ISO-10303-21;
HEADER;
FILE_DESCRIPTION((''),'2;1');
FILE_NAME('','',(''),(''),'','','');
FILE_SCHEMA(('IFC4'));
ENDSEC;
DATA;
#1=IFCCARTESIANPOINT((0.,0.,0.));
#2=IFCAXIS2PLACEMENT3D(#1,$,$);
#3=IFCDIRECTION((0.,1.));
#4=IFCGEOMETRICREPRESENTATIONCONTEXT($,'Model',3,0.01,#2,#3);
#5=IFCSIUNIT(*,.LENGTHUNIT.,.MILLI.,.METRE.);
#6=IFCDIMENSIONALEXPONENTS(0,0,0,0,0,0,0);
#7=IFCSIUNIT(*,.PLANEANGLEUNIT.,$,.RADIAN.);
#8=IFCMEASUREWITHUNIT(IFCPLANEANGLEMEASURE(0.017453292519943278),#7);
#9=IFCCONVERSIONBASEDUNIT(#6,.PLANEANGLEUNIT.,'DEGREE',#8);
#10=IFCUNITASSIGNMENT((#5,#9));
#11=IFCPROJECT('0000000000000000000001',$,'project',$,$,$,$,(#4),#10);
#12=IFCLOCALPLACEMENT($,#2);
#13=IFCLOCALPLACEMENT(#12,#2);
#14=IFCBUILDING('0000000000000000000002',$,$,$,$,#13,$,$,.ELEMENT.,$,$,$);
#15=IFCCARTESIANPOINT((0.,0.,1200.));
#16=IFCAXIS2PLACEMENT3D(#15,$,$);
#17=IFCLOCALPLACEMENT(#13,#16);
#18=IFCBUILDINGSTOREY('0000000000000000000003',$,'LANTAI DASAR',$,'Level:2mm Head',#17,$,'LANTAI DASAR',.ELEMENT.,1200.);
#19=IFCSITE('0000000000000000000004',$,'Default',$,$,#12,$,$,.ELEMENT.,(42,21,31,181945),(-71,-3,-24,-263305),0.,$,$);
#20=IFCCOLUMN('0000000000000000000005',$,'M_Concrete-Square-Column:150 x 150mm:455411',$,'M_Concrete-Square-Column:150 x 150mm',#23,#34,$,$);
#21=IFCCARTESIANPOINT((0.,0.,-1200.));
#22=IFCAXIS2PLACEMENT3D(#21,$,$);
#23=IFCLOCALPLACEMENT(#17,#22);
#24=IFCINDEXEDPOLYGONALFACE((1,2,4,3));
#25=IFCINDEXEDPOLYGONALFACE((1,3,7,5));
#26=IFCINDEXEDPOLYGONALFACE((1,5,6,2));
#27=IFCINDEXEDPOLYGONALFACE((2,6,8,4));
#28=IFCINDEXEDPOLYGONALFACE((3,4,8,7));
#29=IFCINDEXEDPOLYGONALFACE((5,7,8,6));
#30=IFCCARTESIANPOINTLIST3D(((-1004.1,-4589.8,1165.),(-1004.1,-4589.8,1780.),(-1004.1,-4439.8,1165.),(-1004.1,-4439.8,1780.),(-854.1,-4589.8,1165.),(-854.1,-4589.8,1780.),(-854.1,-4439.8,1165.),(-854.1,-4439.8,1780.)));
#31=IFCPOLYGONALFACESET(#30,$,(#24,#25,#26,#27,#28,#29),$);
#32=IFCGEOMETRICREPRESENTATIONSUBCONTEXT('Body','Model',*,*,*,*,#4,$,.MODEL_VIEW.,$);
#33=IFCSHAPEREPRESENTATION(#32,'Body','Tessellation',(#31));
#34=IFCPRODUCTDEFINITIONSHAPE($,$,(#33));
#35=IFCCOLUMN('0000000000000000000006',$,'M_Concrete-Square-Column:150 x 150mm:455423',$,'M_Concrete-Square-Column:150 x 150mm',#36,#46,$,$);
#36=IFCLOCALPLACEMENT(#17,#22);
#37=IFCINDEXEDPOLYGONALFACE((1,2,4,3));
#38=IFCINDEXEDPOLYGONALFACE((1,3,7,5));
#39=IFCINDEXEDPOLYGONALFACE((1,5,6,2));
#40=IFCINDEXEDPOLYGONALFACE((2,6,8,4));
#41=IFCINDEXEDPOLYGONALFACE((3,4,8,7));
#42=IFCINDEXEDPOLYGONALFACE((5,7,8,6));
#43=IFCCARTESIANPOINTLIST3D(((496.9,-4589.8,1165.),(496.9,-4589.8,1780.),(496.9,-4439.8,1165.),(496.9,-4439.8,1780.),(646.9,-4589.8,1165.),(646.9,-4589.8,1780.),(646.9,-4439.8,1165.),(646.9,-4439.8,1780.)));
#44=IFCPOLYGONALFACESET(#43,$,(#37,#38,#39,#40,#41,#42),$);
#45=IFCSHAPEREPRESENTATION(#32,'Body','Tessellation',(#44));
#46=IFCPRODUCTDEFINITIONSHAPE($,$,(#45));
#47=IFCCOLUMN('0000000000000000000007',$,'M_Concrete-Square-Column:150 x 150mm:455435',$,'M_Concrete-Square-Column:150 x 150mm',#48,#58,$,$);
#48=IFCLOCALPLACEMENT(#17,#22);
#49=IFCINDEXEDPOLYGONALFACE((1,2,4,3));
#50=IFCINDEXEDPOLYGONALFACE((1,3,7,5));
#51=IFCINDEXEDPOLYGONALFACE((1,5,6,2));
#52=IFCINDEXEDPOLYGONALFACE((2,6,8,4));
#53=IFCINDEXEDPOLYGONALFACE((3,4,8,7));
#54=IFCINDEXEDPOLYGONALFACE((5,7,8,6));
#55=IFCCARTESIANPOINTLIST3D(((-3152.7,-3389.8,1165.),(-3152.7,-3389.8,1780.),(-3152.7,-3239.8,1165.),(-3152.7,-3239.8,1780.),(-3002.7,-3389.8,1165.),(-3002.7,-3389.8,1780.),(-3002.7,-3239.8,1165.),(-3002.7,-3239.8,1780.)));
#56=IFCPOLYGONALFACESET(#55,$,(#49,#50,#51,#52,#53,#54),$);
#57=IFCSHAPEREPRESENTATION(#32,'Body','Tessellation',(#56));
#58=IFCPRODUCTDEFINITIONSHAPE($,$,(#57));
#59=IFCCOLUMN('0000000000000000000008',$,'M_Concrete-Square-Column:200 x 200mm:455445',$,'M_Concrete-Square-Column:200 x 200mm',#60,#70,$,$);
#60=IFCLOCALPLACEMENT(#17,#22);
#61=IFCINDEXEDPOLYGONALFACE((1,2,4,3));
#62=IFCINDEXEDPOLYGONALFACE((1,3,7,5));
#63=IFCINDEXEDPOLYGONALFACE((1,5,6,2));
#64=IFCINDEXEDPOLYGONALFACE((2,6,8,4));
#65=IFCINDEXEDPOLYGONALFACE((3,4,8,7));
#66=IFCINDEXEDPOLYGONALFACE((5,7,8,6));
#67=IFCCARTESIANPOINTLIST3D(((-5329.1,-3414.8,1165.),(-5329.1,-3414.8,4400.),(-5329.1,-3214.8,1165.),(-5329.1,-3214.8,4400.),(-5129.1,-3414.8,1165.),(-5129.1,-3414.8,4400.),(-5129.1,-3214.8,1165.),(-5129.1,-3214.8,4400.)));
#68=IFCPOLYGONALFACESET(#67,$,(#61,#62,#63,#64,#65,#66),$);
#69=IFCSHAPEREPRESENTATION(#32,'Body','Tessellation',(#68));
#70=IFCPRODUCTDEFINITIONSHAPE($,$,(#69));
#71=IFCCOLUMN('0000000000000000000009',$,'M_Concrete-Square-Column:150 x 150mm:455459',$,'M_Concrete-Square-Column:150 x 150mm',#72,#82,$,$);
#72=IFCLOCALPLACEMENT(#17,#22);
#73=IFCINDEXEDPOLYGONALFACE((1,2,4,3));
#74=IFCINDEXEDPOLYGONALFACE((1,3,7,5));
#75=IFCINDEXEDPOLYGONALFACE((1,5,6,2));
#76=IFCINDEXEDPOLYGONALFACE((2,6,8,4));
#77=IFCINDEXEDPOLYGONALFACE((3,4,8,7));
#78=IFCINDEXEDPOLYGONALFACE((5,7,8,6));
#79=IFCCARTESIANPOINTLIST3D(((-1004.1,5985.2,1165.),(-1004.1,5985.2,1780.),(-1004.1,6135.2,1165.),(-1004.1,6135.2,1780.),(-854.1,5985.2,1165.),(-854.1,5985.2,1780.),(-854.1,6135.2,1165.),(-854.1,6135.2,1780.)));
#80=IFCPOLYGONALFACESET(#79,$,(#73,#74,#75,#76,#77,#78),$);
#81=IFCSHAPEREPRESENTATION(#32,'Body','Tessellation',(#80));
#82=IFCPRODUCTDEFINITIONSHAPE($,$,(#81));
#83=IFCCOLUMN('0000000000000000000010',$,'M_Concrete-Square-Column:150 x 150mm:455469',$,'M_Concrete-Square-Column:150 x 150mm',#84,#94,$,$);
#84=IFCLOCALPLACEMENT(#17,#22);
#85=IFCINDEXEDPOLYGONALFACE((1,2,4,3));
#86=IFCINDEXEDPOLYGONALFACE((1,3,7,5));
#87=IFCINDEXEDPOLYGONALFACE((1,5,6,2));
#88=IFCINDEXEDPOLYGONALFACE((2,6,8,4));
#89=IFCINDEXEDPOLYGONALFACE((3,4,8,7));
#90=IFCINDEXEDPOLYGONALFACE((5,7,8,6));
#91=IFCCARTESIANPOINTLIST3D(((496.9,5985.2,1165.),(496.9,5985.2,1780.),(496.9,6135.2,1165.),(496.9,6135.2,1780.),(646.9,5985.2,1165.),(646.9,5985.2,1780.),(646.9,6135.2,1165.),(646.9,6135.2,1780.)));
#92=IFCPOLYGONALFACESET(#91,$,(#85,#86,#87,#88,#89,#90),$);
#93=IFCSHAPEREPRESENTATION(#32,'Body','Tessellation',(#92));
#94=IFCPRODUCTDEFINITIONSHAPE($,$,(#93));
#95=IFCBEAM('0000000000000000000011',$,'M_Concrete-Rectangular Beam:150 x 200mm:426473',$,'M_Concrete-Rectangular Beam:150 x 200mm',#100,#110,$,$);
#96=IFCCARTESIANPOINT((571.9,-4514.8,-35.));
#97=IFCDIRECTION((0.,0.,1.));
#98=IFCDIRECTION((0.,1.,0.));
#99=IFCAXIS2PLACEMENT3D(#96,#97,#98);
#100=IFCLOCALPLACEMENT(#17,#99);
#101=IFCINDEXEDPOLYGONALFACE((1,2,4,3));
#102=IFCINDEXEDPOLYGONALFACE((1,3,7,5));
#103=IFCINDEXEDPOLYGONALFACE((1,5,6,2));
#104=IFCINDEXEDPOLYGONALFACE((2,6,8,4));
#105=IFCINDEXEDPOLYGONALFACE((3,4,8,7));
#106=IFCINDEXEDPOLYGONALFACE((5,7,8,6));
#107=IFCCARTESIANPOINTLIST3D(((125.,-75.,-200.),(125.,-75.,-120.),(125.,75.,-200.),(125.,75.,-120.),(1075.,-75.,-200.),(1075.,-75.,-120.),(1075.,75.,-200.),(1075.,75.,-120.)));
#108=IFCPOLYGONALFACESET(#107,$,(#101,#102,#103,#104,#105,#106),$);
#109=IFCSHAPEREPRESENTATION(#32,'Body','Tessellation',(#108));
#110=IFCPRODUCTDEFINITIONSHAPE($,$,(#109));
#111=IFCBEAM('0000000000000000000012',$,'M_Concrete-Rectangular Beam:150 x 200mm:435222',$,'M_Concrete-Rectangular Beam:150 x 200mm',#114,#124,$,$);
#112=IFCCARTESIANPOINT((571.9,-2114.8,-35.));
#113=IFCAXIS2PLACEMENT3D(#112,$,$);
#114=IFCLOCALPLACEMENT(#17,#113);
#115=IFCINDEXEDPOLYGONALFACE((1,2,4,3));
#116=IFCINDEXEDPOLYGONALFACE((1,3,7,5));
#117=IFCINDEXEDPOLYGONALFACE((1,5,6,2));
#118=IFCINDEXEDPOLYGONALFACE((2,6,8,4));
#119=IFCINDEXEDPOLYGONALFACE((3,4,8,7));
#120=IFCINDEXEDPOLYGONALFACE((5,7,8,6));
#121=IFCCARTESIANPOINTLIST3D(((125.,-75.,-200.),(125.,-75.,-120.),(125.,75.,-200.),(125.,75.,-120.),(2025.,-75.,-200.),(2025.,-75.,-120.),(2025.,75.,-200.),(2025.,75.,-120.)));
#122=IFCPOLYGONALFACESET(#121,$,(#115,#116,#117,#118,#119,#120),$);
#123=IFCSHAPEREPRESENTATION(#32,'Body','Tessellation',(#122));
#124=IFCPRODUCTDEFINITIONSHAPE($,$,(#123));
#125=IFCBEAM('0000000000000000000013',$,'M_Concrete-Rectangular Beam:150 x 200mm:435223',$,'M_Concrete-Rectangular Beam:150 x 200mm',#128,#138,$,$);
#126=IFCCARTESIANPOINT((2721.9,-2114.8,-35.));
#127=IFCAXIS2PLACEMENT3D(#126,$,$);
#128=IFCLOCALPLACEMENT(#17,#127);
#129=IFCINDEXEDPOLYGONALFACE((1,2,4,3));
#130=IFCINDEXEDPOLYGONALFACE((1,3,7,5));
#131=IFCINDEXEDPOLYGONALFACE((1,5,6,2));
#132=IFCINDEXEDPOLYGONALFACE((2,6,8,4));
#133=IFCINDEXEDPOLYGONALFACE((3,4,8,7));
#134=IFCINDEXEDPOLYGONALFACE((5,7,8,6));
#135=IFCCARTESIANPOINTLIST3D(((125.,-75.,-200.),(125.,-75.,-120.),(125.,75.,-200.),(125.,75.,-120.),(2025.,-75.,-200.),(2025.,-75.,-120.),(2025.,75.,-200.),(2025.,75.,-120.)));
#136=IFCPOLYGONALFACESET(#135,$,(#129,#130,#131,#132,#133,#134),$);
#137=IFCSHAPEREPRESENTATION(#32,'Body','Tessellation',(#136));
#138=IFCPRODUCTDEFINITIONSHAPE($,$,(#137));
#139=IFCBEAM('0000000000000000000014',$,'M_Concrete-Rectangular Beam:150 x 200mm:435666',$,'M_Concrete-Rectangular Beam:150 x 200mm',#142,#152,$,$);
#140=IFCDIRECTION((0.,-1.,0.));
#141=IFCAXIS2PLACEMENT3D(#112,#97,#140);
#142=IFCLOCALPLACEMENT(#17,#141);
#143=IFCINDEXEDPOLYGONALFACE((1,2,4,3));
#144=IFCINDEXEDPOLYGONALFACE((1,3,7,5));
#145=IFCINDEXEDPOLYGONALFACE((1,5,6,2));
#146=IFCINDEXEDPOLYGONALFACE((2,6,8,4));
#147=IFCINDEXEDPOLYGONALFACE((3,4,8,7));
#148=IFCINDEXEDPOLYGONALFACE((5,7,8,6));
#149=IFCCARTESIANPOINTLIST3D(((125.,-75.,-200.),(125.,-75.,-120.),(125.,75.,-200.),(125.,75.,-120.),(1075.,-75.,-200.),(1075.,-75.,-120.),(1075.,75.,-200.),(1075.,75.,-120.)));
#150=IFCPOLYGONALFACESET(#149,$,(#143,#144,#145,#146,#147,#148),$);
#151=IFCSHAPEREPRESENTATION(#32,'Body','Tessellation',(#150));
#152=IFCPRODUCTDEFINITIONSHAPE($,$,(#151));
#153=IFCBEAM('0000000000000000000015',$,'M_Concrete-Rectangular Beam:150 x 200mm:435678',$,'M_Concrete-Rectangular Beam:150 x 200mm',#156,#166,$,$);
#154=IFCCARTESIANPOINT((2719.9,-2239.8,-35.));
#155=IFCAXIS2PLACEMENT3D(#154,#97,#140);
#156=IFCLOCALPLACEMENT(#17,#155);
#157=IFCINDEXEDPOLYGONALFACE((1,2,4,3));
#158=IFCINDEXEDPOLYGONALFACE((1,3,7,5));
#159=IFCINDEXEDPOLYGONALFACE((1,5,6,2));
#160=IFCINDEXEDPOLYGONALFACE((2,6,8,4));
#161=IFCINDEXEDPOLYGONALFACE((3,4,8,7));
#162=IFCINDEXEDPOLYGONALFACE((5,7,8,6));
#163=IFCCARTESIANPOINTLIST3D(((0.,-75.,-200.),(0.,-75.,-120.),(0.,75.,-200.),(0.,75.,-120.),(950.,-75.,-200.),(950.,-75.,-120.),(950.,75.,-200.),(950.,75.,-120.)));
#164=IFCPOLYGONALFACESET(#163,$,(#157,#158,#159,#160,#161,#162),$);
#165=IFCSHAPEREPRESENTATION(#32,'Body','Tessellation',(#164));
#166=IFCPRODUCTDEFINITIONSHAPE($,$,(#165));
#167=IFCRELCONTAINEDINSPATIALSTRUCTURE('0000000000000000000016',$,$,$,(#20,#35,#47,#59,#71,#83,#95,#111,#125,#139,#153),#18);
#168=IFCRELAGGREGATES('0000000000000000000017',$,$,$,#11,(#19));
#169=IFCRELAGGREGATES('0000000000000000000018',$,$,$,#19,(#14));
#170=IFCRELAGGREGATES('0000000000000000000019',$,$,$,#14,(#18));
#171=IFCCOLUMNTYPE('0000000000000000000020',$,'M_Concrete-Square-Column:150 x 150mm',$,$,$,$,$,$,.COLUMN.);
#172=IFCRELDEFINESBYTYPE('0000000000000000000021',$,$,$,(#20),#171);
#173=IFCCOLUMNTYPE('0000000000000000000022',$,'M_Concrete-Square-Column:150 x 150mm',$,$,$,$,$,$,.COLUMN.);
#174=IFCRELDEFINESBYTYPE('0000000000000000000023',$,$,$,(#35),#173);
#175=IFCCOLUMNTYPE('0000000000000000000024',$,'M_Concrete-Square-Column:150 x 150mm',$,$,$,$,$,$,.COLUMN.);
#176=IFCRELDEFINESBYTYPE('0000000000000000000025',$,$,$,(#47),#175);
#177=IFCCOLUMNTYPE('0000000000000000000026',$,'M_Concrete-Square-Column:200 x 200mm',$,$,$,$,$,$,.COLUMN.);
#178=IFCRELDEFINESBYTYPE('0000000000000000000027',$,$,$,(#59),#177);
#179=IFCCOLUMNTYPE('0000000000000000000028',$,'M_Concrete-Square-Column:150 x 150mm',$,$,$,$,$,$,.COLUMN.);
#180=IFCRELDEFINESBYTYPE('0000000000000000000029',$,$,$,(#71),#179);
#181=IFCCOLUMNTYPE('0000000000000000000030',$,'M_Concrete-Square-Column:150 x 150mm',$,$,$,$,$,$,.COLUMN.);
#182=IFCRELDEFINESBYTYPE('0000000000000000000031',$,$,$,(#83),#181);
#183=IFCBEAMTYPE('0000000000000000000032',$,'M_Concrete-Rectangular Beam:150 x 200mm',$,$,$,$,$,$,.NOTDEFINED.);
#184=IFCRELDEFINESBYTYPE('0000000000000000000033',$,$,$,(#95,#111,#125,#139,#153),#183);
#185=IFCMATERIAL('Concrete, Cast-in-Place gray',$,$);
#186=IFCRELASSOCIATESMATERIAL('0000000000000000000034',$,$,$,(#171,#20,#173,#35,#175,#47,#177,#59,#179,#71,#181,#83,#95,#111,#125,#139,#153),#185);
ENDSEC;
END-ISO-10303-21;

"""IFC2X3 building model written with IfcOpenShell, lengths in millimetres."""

from ifc_helpers import new_model, entity, si_unit, converted_unit, direction, frame, frame_2d, origin, origin_2d_with_axis, place, context, subcontext, project, spatial, rectangle, extrude, source, transform, mapped, material, type_object, type_shapes, element, save


model = new_model("IFC2X3")

# Units and contexts
model_context = context("Model", 3, precision=0.01, world=origin(), true_north=direction((0.0, 1.0)))
body_context = subcontext(model_context, "Body", "Model", "MODEL_VIEW")
ifc_project = project(units=[si_unit("LENGTHUNIT", "METRE", prefix="MILLI"), converted_unit("PLANEANGLEUNIT", "DEGREE", entity("IfcPlaneAngleMeasure", 0.017453292519943278), si_unit("PLANEANGLEUNIT", "RADIAN"), dimensions=[0, 0, 0, 0, 0, 0, 0])], contexts=[model_context])

# Site, building, storey
site_placement = place(None, origin())
site = spatial("IfcSite", under=ifc_project, at=site_placement, Name="Default", CompositionType="ELEMENT", RefLatitude=(42, 21, 31, 181945), RefLongitude=(-71, -3, -24, -263305), RefElevation=0.0)
building_placement = place(site_placement, origin())
building = spatial("IfcBuilding", under=site, at=building_placement, CompositionType="ELEMENT")
storey_placement = place(building_placement, frame((0.0, 0.0, 1200.0)))
storey = spatial("IfcBuildingStorey", under=building, at=storey_placement, Name="LANTAI DASAR", ObjectType="Level:2mm Head", LongName="LANTAI DASAR", CompositionType="ELEMENT", Elevation=1200.0)

# Columns
ifc_material = material(Name="Concrete, Cast-in-Place gray")
column_type_1 = type_object("IfcColumnType", Name="M_Concrete-Square-Column:150 x 150mm", PredefinedType="COLUMN", material=ifc_material)
shared_shape_1 = source(origin(), body_context, "Body", "SweptSolid", [
    extrude(rectangle(XDim=150.0, YDim=150.0, at=frame_2d((0.0, 0.0), x_axis=(1.0, 0.0))), frame((-929.1, -4514.8, 1165.0), z_axis=(0.0, 0.0, 1.0), x_axis=(-1.0, 0.0, 0.0)), (0.0, 0.0, 1.0), 615.0),
])
type_shapes(column_type_1, [shared_shape_1])
column_1_placement = place(storey_placement, frame((0.0, 0.0, -1200.0)))
element("IfcColumn", 1, at=column_1_placement, inside=storey, type_object=column_type_1, material=ifc_material, Name="M_Concrete-Square-Column:150 x 150mm:455411", ObjectType="M_Concrete-Square-Column:150 x 150mm", context=body_context, shape_type="MappedRepresentation", body=[
    mapped(shared_shape_1, transform((0.0, 0.0, 0.0), scale=1.0)),
])
column_type_2 = type_object("IfcColumnType", Name="M_Concrete-Square-Column:150 x 150mm", PredefinedType="COLUMN", material=ifc_material)
shared_shape_2 = source(origin(), body_context, "Body", "SweptSolid", [
    extrude(rectangle(XDim=150.0, YDim=150.0, at=frame_2d((0.0, 0.0), x_axis=(1.0, 0.0))), frame((571.9, -4514.8, 1165.0), z_axis=(0.0, 0.0, 1.0), x_axis=(-1.0, 0.0, 0.0)), (0.0, 0.0, 1.0), 615.0),
])
type_shapes(column_type_2, [shared_shape_2])
column_2_placement = place(storey_placement, frame((0.0, 0.0, -1200.0)))
element("IfcColumn", 2, at=column_2_placement, inside=storey, type_object=column_type_2, material=ifc_material, Name="M_Concrete-Square-Column:150 x 150mm:455423", ObjectType="M_Concrete-Square-Column:150 x 150mm", context=body_context, shape_type="MappedRepresentation", body=[
    mapped(shared_shape_2, transform((0.0, 0.0, 0.0), scale=1.0)),
])
column_type_3 = type_object("IfcColumnType", Name="M_Concrete-Square-Column:150 x 150mm", PredefinedType="COLUMN", material=ifc_material)
shared_shape_3 = source(origin(), body_context, "Body", "SweptSolid", [
    extrude(rectangle(XDim=150.0, YDim=150.0, at=frame_2d((0.0, 0.0), x_axis=(1.0, 0.0))), frame((-3077.7, -3314.8, 1165.0), z_axis=(0.0, 0.0, 1.0), x_axis=(-1.0, 0.0, 0.0)), (0.0, 0.0, 1.0), 615.0),
])
type_shapes(column_type_3, [shared_shape_3])
column_3_placement = place(storey_placement, frame((0.0, 0.0, -1200.0)))
element("IfcColumn", 3, at=column_3_placement, inside=storey, type_object=column_type_3, material=ifc_material, Name="M_Concrete-Square-Column:150 x 150mm:455435", ObjectType="M_Concrete-Square-Column:150 x 150mm", context=body_context, shape_type="MappedRepresentation", body=[
    mapped(shared_shape_3, transform((0.0, 0.0, 0.0), scale=1.0)),
])
column_type_4 = type_object("IfcColumnType", Name="M_Concrete-Square-Column:200 x 200mm", PredefinedType="COLUMN", material=ifc_material)
shared_shape_4 = source(origin(), body_context, "Body", "SweptSolid", [
    extrude(rectangle(XDim=200.0, YDim=200.0, at=origin_2d_with_axis()), frame((-5229.1, -3314.8, 1165.0), z_axis=(0.0, 0.0, 1.0), x_axis=(-1.0, 0.0, 0.0)), (0.0, 0.0, 1.0), 3235.0),
])
type_shapes(column_type_4, [shared_shape_4])
column_4_placement = place(storey_placement, frame((0.0, 0.0, -1200.0)))
element("IfcColumn", 4, at=column_4_placement, inside=storey, type_object=column_type_4, material=ifc_material, Name="M_Concrete-Square-Column:200 x 200mm:455445", ObjectType="M_Concrete-Square-Column:200 x 200mm", context=body_context, shape_type="MappedRepresentation", body=[
    mapped(shared_shape_4, transform((0.0, 0.0, 0.0), scale=1.0)),
])
column_type_5 = type_object("IfcColumnType", Name="M_Concrete-Square-Column:150 x 150mm", PredefinedType="COLUMN", material=ifc_material)
shared_shape_5 = source(origin(), body_context, "Body", "SweptSolid", [
    extrude(rectangle(XDim=150.0, YDim=150.0, at=frame_2d((0.0, 0.0), x_axis=(1.0, 0.0))), frame((-929.1, 6060.2, 1165.0), z_axis=(0.0, 0.0, 1.0), x_axis=(-1.0, 0.0, 0.0)), (0.0, 0.0, 1.0), 615.0),
])
type_shapes(column_type_5, [shared_shape_5])
column_5_placement = place(storey_placement, frame((0.0, 0.0, -1200.0)))
element("IfcColumn", 5, at=column_5_placement, inside=storey, type_object=column_type_5, material=ifc_material, Name="M_Concrete-Square-Column:150 x 150mm:455459", ObjectType="M_Concrete-Square-Column:150 x 150mm", context=body_context, shape_type="MappedRepresentation", body=[
    mapped(shared_shape_5, transform((0.0, 0.0, 0.0), scale=1.0)),
])
column_type_6 = type_object("IfcColumnType", Name="M_Concrete-Square-Column:150 x 150mm", PredefinedType="COLUMN", material=ifc_material)
shared_shape_6 = source(origin(), body_context, "Body", "SweptSolid", [
    extrude(rectangle(XDim=150.0, YDim=150.0, at=frame_2d((0.0, 0.0), x_axis=(1.0, 0.0))), frame((571.9, 6060.2, 1165.0), z_axis=(0.0, 0.0, 1.0), x_axis=(-1.0, 0.0, 0.0)), (0.0, 0.0, 1.0), 615.0),
])
type_shapes(column_type_6, [shared_shape_6])
column_6_placement = place(storey_placement, frame((0.0, 0.0, -1200.0)))
element("IfcColumn", 6, at=column_6_placement, inside=storey, type_object=column_type_6, material=ifc_material, Name="M_Concrete-Square-Column:150 x 150mm:455469", ObjectType="M_Concrete-Square-Column:150 x 150mm", context=body_context, shape_type="MappedRepresentation", body=[
    mapped(shared_shape_6, transform((0.0, 0.0, 0.0), scale=1.0)),
])

# Beams
beam_type = type_object("IfcBeamType", Name="M_Concrete-Rectangular Beam:150 x 200mm", PredefinedType="NOTDEFINED")
beam_1_placement = place(storey_placement, frame((571.9, -4514.8, -35.0), z_axis=(0.0, 0.0, 1.0), x_axis=(0.0, 1.0, 0.0)))
element("IfcBeam", 7, at=beam_1_placement, inside=storey, type_object=beam_type, material=ifc_material, Name="M_Concrete-Rectangular Beam:150 x 200mm:426473", ObjectType="M_Concrete-Rectangular Beam:150 x 200mm", context=body_context, shape_type="SweptSolid", body=[
    extrude(rectangle(XDim=80.0, YDim=150.0, at=frame_2d((0.0, 0.0), x_axis=(1.0, 0.0))), frame((125.0, 0.0, -160.0), z_axis=(1.0, 0.0, 0.0), x_axis=(0.0, 0.0, -1.0)), (0.0, 0.0, 1.0), 950.0),
])
beam_2_placement = place(storey_placement, frame((571.9, -2114.8, -35.0)))
element("IfcBeam", 8, at=beam_2_placement, inside=storey, type_object=beam_type, material=ifc_material, Name="M_Concrete-Rectangular Beam:150 x 200mm:435222", ObjectType="M_Concrete-Rectangular Beam:150 x 200mm", context=body_context, shape_type="SweptSolid", body=[
    extrude(rectangle(XDim=80.0, YDim=150.0, at=frame_2d((0.0, 0.0), x_axis=(1.0, 0.0))), frame((125.0, 0.0, -160.0), z_axis=(1.0, 0.0, 0.0), x_axis=(0.0, 0.0, -1.0)), (0.0, 0.0, 1.0), 1900.0),
])
beam_3_placement = place(storey_placement, frame((2721.9, -2114.8, -35.0)))
element("IfcBeam", 9, at=beam_3_placement, inside=storey, type_object=beam_type, material=ifc_material, Name="M_Concrete-Rectangular Beam:150 x 200mm:435223", ObjectType="M_Concrete-Rectangular Beam:150 x 200mm", context=body_context, shape_type="SweptSolid", body=[
    extrude(rectangle(XDim=80.0, YDim=150.0, at=frame_2d((0.0, 0.0), x_axis=(1.0, 0.0))), frame((125.0, 0.0, -160.0), z_axis=(1.0, 0.0, 0.0), x_axis=(0.0, 0.0, -1.0)), (0.0, 0.0, 1.0), 1900.0),
])
beam_4_placement = place(storey_placement, frame((571.9, -2114.8, -35.0), z_axis=(0.0, 0.0, 1.0), x_axis=(0.0, -1.0, 0.0)))
element("IfcBeam", 10, at=beam_4_placement, inside=storey, type_object=beam_type, material=ifc_material, Name="M_Concrete-Rectangular Beam:150 x 200mm:435666", ObjectType="M_Concrete-Rectangular Beam:150 x 200mm", context=body_context, shape_type="SweptSolid", body=[
    extrude(rectangle(XDim=80.0, YDim=150.0, at=frame_2d((0.0, 0.0), x_axis=(1.0, 0.0))), frame((125.0, 0.0, -160.0), z_axis=(1.0, 0.0, 0.0), x_axis=(0.0, 0.0, -1.0)), (0.0, 0.0, 1.0), 950.0),
])
beam_5_placement = place(storey_placement, frame((2719.9, -2239.8, -35.0), z_axis=(0.0, 0.0, 1.0), x_axis=(0.0, -1.0, 0.0)))
element("IfcBeam", 11, at=beam_5_placement, inside=storey, type_object=beam_type, material=ifc_material, Name="M_Concrete-Rectangular Beam:150 x 200mm:435678", ObjectType="M_Concrete-Rectangular Beam:150 x 200mm", context=body_context, shape_type="SweptSolid", body=[
    extrude(rectangle(XDim=80.0, YDim=150.0, at=frame_2d((0.0, 0.0), x_axis=(1.0, 0.0))), frame((0.0, 0.0, -160.0), z_axis=(1.0, 0.0, 0.0), x_axis=(0.0, 0.0, -1.0)), (0.0, 0.0, 1.0), 950.0),
])

save(model, "model.ifc")
